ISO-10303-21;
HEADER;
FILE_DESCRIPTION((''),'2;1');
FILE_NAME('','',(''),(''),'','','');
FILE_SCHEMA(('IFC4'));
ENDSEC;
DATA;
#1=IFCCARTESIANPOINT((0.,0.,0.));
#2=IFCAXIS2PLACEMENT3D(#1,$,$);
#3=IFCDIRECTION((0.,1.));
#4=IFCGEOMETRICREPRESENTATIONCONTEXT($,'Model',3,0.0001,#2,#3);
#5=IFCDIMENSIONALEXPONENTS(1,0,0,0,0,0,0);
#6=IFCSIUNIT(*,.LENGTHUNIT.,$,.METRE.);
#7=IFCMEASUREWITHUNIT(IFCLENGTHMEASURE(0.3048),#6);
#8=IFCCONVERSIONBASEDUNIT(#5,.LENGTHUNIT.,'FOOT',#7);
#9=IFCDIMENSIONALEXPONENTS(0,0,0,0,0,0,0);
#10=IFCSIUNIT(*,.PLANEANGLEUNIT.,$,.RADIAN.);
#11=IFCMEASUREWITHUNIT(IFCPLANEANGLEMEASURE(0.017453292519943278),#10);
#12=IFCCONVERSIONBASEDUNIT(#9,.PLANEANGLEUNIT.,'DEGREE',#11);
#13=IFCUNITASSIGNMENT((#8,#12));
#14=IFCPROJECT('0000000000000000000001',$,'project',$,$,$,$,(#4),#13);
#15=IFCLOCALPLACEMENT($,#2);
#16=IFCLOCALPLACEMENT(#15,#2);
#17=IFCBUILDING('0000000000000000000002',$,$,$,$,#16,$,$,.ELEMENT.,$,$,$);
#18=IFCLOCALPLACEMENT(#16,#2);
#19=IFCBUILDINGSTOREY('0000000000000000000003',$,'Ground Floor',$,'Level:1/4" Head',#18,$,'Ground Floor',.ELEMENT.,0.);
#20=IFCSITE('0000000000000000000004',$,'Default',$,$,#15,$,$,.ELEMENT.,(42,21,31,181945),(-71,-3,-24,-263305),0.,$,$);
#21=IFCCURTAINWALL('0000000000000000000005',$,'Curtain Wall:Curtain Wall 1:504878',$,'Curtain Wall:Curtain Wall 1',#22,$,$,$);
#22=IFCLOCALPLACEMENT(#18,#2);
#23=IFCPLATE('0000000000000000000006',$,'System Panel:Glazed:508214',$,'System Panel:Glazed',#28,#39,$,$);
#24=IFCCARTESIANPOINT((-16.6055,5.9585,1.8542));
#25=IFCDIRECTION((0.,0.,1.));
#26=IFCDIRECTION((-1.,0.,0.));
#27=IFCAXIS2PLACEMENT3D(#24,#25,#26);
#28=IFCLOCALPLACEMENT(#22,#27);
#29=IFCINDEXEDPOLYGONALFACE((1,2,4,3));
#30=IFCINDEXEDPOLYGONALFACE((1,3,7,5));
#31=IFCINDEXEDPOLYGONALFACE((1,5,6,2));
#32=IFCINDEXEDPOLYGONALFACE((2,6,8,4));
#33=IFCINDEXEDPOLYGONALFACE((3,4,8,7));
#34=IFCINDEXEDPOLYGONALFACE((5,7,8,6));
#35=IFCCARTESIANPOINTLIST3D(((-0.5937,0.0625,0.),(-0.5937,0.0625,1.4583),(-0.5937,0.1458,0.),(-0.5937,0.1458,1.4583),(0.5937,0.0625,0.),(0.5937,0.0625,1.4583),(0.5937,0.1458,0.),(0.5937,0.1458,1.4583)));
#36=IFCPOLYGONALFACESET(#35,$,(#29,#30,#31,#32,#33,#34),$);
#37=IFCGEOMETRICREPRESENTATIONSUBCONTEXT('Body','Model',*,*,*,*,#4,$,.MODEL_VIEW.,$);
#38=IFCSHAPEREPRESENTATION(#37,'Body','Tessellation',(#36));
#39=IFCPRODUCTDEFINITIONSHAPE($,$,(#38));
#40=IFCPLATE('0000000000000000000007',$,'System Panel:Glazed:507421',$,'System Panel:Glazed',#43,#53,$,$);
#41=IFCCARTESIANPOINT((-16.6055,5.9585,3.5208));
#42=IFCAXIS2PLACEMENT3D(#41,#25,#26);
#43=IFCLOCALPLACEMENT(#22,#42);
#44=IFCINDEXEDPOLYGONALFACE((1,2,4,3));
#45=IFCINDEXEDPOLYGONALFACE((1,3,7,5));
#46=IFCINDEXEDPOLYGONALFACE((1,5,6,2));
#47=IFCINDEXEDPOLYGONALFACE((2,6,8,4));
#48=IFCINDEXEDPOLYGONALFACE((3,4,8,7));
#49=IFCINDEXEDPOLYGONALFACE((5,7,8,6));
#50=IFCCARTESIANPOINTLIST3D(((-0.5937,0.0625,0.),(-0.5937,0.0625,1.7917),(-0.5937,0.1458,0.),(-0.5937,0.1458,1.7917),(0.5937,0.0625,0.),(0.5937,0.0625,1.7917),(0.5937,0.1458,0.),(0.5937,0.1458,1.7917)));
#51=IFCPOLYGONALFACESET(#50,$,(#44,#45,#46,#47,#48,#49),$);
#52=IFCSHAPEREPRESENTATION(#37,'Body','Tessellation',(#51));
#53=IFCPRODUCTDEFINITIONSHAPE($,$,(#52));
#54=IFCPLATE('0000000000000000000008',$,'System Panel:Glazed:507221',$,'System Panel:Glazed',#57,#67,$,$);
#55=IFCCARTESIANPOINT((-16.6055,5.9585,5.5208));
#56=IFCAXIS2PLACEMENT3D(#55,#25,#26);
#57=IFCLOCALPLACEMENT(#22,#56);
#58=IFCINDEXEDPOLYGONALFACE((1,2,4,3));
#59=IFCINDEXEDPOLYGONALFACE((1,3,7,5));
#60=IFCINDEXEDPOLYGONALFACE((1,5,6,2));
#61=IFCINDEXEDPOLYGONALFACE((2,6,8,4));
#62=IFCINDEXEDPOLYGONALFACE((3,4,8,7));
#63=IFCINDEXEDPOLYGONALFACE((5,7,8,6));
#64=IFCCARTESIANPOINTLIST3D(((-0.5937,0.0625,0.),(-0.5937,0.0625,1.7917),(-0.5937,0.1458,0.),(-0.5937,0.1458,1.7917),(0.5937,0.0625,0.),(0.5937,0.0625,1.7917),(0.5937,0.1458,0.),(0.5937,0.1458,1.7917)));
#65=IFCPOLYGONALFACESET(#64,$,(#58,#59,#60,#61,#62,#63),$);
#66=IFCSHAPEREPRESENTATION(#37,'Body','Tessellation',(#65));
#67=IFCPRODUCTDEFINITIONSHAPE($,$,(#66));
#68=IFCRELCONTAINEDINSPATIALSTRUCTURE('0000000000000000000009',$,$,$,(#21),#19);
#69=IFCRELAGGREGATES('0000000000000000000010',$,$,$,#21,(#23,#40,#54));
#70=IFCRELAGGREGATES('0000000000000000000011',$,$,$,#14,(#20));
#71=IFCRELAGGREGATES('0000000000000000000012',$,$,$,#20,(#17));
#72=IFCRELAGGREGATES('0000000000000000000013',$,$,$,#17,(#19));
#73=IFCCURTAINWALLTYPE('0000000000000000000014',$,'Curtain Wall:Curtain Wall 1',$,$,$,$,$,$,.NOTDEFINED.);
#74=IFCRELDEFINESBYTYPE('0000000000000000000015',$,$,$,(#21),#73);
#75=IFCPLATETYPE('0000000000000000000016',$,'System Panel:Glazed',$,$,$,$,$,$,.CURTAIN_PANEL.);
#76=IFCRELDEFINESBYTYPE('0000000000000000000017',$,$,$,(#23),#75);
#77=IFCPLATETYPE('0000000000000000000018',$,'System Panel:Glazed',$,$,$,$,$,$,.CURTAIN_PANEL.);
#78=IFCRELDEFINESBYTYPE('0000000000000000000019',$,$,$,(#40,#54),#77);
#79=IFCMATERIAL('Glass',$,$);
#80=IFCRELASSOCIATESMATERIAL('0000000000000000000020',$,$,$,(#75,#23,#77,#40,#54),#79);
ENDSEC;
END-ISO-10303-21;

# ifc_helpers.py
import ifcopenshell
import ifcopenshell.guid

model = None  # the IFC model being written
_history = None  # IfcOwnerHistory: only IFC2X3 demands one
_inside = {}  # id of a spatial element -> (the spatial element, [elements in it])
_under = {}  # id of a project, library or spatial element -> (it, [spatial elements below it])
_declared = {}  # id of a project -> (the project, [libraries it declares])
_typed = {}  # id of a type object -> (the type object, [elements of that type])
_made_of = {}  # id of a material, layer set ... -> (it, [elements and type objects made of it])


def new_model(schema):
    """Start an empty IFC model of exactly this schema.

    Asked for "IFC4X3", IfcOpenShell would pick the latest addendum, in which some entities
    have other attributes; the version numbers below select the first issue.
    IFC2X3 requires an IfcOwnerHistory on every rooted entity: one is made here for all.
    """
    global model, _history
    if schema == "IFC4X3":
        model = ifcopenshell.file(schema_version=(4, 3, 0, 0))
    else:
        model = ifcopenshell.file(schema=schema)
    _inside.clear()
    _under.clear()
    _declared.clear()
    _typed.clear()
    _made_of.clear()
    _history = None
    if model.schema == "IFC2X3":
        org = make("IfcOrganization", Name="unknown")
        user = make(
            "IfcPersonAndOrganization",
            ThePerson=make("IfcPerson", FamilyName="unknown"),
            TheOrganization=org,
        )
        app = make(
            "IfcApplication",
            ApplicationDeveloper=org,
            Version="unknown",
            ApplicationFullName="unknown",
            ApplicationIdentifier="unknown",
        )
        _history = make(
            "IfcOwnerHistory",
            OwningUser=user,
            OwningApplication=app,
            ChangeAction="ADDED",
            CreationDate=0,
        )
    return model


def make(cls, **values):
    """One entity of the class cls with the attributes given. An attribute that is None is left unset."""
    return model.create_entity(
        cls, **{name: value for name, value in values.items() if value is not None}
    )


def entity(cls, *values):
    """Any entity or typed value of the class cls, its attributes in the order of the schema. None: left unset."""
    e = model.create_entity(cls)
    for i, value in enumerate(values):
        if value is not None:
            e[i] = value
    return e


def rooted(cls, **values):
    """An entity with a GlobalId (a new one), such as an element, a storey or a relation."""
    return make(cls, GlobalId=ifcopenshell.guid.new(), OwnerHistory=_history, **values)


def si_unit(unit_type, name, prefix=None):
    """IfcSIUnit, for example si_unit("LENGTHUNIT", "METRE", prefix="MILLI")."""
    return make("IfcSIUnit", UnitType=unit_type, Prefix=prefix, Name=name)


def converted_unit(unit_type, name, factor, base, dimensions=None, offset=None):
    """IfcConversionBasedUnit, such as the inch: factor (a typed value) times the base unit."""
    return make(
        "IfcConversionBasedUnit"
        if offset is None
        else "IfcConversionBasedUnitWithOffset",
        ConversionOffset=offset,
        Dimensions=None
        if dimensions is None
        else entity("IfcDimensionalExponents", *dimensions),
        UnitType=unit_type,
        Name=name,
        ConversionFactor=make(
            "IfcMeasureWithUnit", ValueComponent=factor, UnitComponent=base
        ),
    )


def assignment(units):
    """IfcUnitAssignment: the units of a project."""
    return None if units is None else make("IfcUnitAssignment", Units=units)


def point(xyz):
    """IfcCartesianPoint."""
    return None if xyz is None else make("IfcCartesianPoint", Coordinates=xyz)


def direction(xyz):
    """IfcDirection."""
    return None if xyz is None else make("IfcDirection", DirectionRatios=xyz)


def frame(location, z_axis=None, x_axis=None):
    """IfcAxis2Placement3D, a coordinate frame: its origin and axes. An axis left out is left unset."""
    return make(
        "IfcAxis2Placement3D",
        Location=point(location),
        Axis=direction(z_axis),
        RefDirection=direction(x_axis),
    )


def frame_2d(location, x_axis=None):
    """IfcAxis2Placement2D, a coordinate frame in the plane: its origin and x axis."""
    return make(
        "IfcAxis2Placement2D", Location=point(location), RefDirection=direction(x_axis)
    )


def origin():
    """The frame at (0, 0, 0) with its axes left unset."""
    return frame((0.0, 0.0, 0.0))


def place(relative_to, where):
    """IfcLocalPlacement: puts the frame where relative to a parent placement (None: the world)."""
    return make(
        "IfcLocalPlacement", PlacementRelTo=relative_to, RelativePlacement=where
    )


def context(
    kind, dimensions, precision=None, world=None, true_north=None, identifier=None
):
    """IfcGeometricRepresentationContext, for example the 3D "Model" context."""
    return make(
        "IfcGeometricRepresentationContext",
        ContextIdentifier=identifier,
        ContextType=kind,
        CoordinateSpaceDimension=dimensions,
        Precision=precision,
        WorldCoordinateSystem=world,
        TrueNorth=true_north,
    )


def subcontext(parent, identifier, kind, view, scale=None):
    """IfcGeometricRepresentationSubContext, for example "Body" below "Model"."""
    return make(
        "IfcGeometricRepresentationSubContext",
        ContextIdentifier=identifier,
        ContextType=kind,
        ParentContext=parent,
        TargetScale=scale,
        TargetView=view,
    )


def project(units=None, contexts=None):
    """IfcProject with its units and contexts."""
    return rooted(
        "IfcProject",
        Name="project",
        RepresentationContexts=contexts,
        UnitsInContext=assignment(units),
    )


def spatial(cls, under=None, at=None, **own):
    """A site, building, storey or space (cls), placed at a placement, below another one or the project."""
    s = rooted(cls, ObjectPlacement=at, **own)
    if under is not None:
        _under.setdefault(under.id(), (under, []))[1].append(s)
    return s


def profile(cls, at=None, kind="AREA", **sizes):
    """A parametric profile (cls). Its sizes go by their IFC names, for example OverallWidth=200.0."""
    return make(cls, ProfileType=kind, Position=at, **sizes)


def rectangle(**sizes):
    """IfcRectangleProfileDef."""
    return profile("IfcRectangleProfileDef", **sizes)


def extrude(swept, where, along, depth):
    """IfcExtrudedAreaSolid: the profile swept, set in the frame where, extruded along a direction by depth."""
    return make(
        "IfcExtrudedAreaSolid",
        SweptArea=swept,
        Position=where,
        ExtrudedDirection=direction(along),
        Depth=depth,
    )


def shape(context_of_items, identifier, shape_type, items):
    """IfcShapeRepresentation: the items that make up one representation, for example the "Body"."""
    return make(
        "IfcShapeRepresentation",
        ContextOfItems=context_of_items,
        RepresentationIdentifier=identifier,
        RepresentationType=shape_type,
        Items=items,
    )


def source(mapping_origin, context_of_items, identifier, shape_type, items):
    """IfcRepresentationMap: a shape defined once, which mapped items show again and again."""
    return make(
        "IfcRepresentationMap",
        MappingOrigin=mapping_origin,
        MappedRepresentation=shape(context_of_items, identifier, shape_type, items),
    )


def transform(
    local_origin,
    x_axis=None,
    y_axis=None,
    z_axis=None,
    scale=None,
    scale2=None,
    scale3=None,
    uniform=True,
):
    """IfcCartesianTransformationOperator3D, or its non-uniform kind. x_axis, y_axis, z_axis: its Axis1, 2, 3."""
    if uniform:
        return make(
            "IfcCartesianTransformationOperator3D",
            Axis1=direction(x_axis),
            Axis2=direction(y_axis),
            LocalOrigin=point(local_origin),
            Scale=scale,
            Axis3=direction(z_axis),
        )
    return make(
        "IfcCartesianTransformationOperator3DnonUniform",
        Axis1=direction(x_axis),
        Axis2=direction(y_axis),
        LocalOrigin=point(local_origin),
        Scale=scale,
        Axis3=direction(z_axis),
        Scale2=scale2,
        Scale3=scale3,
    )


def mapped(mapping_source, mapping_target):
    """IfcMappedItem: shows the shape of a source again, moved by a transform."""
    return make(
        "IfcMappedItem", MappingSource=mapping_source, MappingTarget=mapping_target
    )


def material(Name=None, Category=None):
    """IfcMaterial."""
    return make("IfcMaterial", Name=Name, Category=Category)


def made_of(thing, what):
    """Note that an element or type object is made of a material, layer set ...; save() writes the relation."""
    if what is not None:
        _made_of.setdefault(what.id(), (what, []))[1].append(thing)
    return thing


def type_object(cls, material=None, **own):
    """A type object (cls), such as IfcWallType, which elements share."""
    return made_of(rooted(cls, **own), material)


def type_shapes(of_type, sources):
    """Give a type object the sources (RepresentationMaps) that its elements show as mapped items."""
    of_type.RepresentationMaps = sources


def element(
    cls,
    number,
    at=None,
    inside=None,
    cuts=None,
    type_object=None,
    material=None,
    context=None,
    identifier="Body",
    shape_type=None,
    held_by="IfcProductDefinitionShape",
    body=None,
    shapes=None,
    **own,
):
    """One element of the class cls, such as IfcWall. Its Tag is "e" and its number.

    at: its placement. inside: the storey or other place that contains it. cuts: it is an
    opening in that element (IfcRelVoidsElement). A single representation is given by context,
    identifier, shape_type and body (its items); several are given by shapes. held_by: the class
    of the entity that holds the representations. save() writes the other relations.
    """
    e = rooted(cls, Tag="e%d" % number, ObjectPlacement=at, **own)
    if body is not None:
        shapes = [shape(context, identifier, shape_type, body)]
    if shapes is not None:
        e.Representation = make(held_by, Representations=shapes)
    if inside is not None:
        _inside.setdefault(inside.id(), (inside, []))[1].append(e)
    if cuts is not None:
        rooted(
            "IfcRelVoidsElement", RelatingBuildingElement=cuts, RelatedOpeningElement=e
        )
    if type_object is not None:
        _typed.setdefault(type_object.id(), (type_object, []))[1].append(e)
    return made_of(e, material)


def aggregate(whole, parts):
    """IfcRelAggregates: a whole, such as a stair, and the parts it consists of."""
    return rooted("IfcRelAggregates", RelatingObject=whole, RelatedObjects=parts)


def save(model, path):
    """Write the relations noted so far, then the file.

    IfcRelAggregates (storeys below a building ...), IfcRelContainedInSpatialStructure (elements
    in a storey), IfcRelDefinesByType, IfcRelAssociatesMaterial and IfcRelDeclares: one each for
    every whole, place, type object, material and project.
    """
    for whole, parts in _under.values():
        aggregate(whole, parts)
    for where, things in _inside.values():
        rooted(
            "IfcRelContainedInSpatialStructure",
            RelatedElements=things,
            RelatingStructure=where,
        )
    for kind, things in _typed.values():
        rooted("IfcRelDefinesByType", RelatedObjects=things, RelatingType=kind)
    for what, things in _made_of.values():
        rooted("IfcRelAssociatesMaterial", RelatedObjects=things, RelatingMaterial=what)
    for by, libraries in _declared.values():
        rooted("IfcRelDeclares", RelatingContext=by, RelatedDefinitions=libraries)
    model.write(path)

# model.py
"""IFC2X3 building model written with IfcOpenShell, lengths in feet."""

from ifc_helpers import new_model, entity, si_unit, converted_unit, direction, frame, frame_2d, origin, place, context, subcontext, project, spatial, rectangle, extrude, source, transform, mapped, material, type_object, type_shapes, element, aggregate, save


model = new_model("IFC2X3")

# Units and contexts
model_context = context("Model", 3, precision=0.0001, world=origin(), true_north=direction((0.0, 1.0)))
body_context = subcontext(model_context, "Body", "Model", "MODEL_VIEW")
ifc_project = project(units=[converted_unit("LENGTHUNIT", "FOOT", entity("IfcLengthMeasure", 0.3048), si_unit("LENGTHUNIT", "METRE"), dimensions=[1, 0, 0, 0, 0, 0, 0]), converted_unit("PLANEANGLEUNIT", "DEGREE", entity("IfcPlaneAngleMeasure", 0.017453292519943278), si_unit("PLANEANGLEUNIT", "RADIAN"), dimensions=[0, 0, 0, 0, 0, 0, 0])], contexts=[model_context])

# Site, building, storey
site_placement = place(None, origin())
site = spatial("IfcSite", under=ifc_project, at=site_placement, Name="Default", CompositionType="ELEMENT", RefLatitude=(42, 21, 31, 181945), RefLongitude=(-71, -3, -24, -263305), RefElevation=0.0)
building_placement = place(site_placement, origin())
building = spatial("IfcBuilding", under=site, at=building_placement, CompositionType="ELEMENT")
storey_placement = place(building_placement, origin())
storey = spatial("IfcBuildingStorey", under=building, at=storey_placement, Name="Ground Floor", ObjectType="Level:1/4\" Head", LongName="Ground Floor", CompositionType="ELEMENT", Elevation=0.0)

# Curtain wall, plates
curtain_wall_type = type_object("IfcCurtainWallType", Name="Curtain Wall:Curtain Wall 1", PredefinedType="NOTDEFINED")
curtain_wall_placement = place(storey_placement, origin())
curtain_wall = element("IfcCurtainWall", 1, at=curtain_wall_placement, inside=storey, type_object=curtain_wall_type, Name="Curtain Wall:Curtain Wall 1:504878", ObjectType="Curtain Wall:Curtain Wall 1")
ifc_material_1 = material(Name="Glass")
plate_type_1 = type_object("IfcPlateType", Name="System Panel:Glazed", PredefinedType="CURTAIN_PANEL", material=ifc_material_1)
shared_shape_1 = source(origin(), body_context, "Body", "SweptSolid", [
    extrude(rectangle(XDim=0.0833, YDim=1.1875, at=frame_2d((0.0, 0.0), x_axis=(1.0, 0.0))), frame((0.0, 0.1042, 0.0), z_axis=(0.0, 0.0, 1.0), x_axis=(0.0, 1.0, 0.0)), (0.0, 0.0, 1.0), 1.4583),
])
type_shapes(plate_type_1, [shared_shape_1])
plate_1_placement = place(curtain_wall_placement, frame((-16.6055, 5.9585, 1.8542), z_axis=(0.0, 0.0, 1.0), x_axis=(-1.0, 0.0, 0.0)))
plate_1 = element("IfcPlate", 2, at=plate_1_placement, type_object=plate_type_1, material=ifc_material_1, Name="System Panel:Glazed:508214", ObjectType="System Panel:Glazed", context=body_context, shape_type="MappedRepresentation", body=[
    mapped(shared_shape_1, transform((0.0, 0.0, 0.0), scale=1.0)),
])
plate_type_2 = type_object("IfcPlateType", Name="System Panel:Glazed", PredefinedType="CURTAIN_PANEL", material=ifc_material_1)
shared_shape_2 = source(origin(), body_context, "Body", "SweptSolid", [
    extrude(rectangle(XDim=0.0833, YDim=1.1875, at=frame_2d((0.0, 0.0), x_axis=(1.0, 0.0))), frame((0.0, 0.1042, 0.0), z_axis=(0.0, 0.0, 1.0), x_axis=(0.0, 1.0, 0.0)), (0.0, 0.0, 1.0), 1.7917),
])
type_shapes(plate_type_2, [shared_shape_2])
plate_2_placement = place(curtain_wall_placement, frame((-16.6055, 5.9585, 3.5208), z_axis=(0.0, 0.0, 1.0), x_axis=(-1.0, 0.0, 0.0)))
plate_2 = element("IfcPlate", 3, at=plate_2_placement, type_object=plate_type_2, material=ifc_material_1, Name="System Panel:Glazed:507421", ObjectType="System Panel:Glazed", context=body_context, shape_type="MappedRepresentation", body=[
    mapped(shared_shape_2, transform((0.0, 0.0, 0.0), scale=1.0)),
])
plate_3_placement = place(curtain_wall_placement, frame((-16.6055, 5.9585, 5.5208), z_axis=(0.0, 0.0, 1.0), x_axis=(-1.0, 0.0, 0.0)))
plate_3 = element("IfcPlate", 4, at=plate_3_placement, type_object=plate_type_2, material=ifc_material_1, Name="System Panel:Glazed:507221", ObjectType="System Panel:Glazed", context=body_context, shape_type="MappedRepresentation", body=[
    mapped(shared_shape_2, transform((0.0, 0.0, 0.0), scale=1.0)),
])
aggregate(curtain_wall, [plate_1, plate_2, plate_3])

save(model, "model.ifc")
